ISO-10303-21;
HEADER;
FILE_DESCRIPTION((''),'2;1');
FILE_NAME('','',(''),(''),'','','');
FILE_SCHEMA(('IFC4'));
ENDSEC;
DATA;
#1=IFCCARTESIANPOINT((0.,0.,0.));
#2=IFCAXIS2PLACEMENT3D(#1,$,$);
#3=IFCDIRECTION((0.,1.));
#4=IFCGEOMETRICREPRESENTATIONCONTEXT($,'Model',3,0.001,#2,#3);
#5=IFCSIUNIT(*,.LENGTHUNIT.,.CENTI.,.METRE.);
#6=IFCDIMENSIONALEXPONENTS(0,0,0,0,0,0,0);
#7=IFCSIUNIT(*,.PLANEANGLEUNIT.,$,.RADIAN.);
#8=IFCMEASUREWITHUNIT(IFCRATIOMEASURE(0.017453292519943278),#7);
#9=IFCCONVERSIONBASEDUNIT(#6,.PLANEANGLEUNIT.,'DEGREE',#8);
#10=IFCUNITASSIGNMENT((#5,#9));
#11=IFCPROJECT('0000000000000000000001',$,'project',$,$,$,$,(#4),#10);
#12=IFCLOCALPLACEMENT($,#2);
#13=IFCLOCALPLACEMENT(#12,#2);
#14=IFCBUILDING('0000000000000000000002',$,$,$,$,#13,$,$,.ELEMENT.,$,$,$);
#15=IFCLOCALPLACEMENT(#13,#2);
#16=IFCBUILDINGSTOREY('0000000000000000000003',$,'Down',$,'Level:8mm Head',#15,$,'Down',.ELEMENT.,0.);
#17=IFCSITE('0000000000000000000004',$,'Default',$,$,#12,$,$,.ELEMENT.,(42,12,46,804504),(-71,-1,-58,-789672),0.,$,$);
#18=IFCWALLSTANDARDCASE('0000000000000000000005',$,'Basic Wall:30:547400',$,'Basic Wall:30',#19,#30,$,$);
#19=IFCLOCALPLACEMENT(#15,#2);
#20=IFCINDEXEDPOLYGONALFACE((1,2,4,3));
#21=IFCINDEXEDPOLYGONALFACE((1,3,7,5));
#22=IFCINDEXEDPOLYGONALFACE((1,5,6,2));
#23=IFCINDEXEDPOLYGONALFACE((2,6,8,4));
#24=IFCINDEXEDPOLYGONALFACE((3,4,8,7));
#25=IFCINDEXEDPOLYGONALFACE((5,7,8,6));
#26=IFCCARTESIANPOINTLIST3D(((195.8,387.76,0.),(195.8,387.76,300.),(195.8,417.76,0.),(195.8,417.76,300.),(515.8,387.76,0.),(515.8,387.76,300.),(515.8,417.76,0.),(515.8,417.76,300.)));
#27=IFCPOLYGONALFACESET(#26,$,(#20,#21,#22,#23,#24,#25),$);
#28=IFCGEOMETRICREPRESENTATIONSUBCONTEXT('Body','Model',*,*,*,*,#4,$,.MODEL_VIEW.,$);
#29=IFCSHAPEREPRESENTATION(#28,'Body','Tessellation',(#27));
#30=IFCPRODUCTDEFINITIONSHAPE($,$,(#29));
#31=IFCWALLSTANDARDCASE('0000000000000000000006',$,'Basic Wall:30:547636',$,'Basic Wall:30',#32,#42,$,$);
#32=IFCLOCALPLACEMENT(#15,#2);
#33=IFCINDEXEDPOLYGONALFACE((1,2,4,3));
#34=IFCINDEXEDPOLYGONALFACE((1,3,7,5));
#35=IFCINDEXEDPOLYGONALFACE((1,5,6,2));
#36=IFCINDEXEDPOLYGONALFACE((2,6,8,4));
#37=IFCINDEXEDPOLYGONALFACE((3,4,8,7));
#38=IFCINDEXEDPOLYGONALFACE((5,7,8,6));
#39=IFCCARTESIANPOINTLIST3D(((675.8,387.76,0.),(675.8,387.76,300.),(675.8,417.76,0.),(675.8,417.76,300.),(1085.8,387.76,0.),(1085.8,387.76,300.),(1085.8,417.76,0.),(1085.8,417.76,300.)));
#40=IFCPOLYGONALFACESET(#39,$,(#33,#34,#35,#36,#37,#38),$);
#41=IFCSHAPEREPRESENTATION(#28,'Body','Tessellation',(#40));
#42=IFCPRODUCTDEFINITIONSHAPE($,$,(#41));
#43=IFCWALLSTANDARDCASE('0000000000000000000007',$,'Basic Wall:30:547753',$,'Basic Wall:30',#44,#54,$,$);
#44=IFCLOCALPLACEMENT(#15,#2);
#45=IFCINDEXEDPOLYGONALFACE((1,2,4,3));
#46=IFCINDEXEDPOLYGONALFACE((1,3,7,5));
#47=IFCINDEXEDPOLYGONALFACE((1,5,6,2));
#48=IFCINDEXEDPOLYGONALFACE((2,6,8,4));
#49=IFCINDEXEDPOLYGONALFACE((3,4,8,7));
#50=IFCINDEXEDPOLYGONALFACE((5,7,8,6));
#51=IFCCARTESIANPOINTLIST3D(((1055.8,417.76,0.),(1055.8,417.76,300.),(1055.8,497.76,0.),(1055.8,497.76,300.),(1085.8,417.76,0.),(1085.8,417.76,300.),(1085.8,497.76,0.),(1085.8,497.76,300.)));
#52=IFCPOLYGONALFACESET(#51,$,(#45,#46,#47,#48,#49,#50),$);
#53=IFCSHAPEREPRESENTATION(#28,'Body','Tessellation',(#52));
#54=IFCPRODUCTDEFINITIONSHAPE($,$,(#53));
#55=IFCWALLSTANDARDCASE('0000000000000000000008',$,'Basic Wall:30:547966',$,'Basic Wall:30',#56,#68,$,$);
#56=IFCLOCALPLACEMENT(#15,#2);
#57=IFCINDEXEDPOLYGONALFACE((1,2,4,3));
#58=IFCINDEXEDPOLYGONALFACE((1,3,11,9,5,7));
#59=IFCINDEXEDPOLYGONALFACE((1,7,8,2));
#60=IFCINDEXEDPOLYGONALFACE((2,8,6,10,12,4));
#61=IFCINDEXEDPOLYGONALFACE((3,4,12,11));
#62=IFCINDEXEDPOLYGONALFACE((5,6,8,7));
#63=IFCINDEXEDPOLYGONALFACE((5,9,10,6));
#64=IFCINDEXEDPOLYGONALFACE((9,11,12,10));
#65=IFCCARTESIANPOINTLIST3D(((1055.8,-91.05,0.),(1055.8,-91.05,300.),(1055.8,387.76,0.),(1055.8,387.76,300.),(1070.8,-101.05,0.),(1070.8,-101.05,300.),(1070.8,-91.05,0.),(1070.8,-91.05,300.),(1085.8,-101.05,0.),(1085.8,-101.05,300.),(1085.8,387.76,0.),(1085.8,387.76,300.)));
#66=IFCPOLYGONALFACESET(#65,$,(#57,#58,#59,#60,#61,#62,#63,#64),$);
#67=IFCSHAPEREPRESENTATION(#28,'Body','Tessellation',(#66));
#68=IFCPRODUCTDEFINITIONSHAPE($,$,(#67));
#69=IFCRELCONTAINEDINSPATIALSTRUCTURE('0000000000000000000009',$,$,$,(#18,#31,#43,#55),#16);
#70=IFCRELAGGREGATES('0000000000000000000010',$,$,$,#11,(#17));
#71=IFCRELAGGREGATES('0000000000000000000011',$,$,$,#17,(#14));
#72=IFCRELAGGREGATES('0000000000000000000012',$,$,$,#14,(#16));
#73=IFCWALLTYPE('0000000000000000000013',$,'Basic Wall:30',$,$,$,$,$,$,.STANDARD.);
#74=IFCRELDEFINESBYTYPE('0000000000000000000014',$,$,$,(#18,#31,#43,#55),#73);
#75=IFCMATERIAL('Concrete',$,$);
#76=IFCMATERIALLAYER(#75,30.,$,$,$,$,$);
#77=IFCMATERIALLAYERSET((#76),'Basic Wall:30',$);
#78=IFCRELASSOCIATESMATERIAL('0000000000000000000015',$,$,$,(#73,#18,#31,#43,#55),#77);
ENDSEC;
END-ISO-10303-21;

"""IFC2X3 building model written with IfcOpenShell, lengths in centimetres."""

from ifc_helpers import new_model, entity, si_unit, converted_unit, direction, frame, frame_2d, origin, place, context, subcontext, project, spatial, polyline, rectangle, outline, extrude, material, layer, layer_set, layer_usage, type_object, element, save


model = new_model("IFC2X3")

# Units and contexts
model_context = context("Model", 3, precision=0.001, world=origin(), true_north=direction((0.0, 1.0)))
body_context = subcontext(model_context, "Body", "Model", "MODEL_VIEW")
ifc_project = project(units=[si_unit("LENGTHUNIT", "METRE", prefix="CENTI"), converted_unit("PLANEANGLEUNIT", "DEGREE", entity("IfcRatioMeasure", 0.017453292519943278), si_unit("PLANEANGLEUNIT", "RADIAN"), dimensions=[0, 0, 0, 0, 0, 0, 0])], contexts=[model_context])

# Site, building, storey
site_placement = place(None, origin())
site = spatial("IfcSite", under=ifc_project, at=site_placement, Name="Default", CompositionType="ELEMENT", RefLatitude=(42, 12, 46, 804504), RefLongitude=(-71, -1, -58, -789672), RefElevation=0.0)
building_placement = place(site_placement, origin())
building = spatial("IfcBuilding", under=site, at=building_placement, CompositionType="ELEMENT")
storey_placement = place(building_placement, origin())
storey = spatial("IfcBuildingStorey", under=building, at=storey_placement, Name="Down", ObjectType="Level:8mm Head", LongName="Down", CompositionType="ELEMENT", Elevation=0.0)

# Shared definitions
ifc_material = material(Name="Concrete")

# Walls
ifc_layer_1 = layer(ifc_material, 30.0)
ifc_layer_set_1 = layer_set([ifc_layer_1], Name="Basic Wall:30")
wall_type_1 = type_object("IfcWallType", Name="Basic Wall:30", PredefinedType="STANDARD", material=ifc_layer_set_1)
ifc_layer_usage_1 = layer_usage(ifc_layer_set_1, "AXIS2", "NEGATIVE", 15.0)
wall_1_placement = place(storey_placement, frame((195.8, 402.76, 0.0)))
element("IfcWallStandardCase", 1, at=wall_1_placement, inside=storey, type_object=wall_type_1, material=ifc_layer_usage_1, Name="Basic Wall:30:547400", ObjectType="Basic Wall:30", context=body_context, shape_type="SweptSolid", body=[
    extrude(rectangle(XDim=320.0, YDim=30.0, at=frame_2d((160.0, 0.0), x_axis=(-1.0, 0.0))), origin(), (0.0, 0.0, 1.0), 300.0),
])
ifc_layer_usage_2 = layer_usage(ifc_layer_set_1, "AXIS2", "NEGATIVE", 15.0)
wall_2_placement = place(storey_placement, frame((675.8, 402.76, 0.0)))
element("IfcWallStandardCase", 2, at=wall_2_placement, inside=storey, type_object=wall_type_1, material=ifc_layer_usage_2, Name="Basic Wall:30:547636", ObjectType="Basic Wall:30", context=body_context, shape_type="SweptSolid", body=[
    extrude(rectangle(XDim=410.0, YDim=30.0, at=frame_2d((205.0, 0.0), x_axis=(-1.0, 0.0))), origin(), (0.0, 0.0, 1.0), 300.0),
])
ifc_layer_usage_3 = layer_usage(ifc_layer_set_1, "AXIS2", "NEGATIVE", 15.0)
wall_3_placement = place(storey_placement, frame((1070.8, 417.76, 0.0), z_axis=(0.0, 0.0, 1.0), x_axis=(0.0, 1.0, 0.0)))
element("IfcWallStandardCase", 3, at=wall_3_placement, inside=storey, type_object=wall_type_1, material=ifc_layer_usage_3, Name="Basic Wall:30:547753", ObjectType="Basic Wall:30", context=body_context, shape_type="SweptSolid", body=[
    extrude(rectangle(XDim=80.0, YDim=30.0, at=frame_2d((40.0, 0.0), x_axis=(-1.0, 0.0))), origin(), (0.0, 0.0, 1.0), 300.0),
])
ifc_layer_usage_4 = layer_usage(ifc_layer_set_1, "AXIS2", "NEGATIVE", 15.0)
wall_4_placement = place(storey_placement, frame((1070.8, 387.76, 0.0), z_axis=(0.0, 0.0, 1.0), x_axis=(0.0, -1.0, 0.0)))
element("IfcWallStandardCase", 4, at=wall_4_placement, inside=storey, type_object=wall_type_1, material=ifc_layer_usage_4, Name="Basic Wall:30:547966", ObjectType="Basic Wall:30", context=body_context, shape_type="SweptSolid", body=[
    extrude(outline(polyline([(478.81, -15.0), (478.81, 0.0), (488.81, 0.0), (488.81, 15.0), (0.0, 15.0), (0.0, -15.0), (478.81, -15.0)])), origin(), (0.0, 0.0, 1.0), 300.0),
])

save(model, "model.ifc")
